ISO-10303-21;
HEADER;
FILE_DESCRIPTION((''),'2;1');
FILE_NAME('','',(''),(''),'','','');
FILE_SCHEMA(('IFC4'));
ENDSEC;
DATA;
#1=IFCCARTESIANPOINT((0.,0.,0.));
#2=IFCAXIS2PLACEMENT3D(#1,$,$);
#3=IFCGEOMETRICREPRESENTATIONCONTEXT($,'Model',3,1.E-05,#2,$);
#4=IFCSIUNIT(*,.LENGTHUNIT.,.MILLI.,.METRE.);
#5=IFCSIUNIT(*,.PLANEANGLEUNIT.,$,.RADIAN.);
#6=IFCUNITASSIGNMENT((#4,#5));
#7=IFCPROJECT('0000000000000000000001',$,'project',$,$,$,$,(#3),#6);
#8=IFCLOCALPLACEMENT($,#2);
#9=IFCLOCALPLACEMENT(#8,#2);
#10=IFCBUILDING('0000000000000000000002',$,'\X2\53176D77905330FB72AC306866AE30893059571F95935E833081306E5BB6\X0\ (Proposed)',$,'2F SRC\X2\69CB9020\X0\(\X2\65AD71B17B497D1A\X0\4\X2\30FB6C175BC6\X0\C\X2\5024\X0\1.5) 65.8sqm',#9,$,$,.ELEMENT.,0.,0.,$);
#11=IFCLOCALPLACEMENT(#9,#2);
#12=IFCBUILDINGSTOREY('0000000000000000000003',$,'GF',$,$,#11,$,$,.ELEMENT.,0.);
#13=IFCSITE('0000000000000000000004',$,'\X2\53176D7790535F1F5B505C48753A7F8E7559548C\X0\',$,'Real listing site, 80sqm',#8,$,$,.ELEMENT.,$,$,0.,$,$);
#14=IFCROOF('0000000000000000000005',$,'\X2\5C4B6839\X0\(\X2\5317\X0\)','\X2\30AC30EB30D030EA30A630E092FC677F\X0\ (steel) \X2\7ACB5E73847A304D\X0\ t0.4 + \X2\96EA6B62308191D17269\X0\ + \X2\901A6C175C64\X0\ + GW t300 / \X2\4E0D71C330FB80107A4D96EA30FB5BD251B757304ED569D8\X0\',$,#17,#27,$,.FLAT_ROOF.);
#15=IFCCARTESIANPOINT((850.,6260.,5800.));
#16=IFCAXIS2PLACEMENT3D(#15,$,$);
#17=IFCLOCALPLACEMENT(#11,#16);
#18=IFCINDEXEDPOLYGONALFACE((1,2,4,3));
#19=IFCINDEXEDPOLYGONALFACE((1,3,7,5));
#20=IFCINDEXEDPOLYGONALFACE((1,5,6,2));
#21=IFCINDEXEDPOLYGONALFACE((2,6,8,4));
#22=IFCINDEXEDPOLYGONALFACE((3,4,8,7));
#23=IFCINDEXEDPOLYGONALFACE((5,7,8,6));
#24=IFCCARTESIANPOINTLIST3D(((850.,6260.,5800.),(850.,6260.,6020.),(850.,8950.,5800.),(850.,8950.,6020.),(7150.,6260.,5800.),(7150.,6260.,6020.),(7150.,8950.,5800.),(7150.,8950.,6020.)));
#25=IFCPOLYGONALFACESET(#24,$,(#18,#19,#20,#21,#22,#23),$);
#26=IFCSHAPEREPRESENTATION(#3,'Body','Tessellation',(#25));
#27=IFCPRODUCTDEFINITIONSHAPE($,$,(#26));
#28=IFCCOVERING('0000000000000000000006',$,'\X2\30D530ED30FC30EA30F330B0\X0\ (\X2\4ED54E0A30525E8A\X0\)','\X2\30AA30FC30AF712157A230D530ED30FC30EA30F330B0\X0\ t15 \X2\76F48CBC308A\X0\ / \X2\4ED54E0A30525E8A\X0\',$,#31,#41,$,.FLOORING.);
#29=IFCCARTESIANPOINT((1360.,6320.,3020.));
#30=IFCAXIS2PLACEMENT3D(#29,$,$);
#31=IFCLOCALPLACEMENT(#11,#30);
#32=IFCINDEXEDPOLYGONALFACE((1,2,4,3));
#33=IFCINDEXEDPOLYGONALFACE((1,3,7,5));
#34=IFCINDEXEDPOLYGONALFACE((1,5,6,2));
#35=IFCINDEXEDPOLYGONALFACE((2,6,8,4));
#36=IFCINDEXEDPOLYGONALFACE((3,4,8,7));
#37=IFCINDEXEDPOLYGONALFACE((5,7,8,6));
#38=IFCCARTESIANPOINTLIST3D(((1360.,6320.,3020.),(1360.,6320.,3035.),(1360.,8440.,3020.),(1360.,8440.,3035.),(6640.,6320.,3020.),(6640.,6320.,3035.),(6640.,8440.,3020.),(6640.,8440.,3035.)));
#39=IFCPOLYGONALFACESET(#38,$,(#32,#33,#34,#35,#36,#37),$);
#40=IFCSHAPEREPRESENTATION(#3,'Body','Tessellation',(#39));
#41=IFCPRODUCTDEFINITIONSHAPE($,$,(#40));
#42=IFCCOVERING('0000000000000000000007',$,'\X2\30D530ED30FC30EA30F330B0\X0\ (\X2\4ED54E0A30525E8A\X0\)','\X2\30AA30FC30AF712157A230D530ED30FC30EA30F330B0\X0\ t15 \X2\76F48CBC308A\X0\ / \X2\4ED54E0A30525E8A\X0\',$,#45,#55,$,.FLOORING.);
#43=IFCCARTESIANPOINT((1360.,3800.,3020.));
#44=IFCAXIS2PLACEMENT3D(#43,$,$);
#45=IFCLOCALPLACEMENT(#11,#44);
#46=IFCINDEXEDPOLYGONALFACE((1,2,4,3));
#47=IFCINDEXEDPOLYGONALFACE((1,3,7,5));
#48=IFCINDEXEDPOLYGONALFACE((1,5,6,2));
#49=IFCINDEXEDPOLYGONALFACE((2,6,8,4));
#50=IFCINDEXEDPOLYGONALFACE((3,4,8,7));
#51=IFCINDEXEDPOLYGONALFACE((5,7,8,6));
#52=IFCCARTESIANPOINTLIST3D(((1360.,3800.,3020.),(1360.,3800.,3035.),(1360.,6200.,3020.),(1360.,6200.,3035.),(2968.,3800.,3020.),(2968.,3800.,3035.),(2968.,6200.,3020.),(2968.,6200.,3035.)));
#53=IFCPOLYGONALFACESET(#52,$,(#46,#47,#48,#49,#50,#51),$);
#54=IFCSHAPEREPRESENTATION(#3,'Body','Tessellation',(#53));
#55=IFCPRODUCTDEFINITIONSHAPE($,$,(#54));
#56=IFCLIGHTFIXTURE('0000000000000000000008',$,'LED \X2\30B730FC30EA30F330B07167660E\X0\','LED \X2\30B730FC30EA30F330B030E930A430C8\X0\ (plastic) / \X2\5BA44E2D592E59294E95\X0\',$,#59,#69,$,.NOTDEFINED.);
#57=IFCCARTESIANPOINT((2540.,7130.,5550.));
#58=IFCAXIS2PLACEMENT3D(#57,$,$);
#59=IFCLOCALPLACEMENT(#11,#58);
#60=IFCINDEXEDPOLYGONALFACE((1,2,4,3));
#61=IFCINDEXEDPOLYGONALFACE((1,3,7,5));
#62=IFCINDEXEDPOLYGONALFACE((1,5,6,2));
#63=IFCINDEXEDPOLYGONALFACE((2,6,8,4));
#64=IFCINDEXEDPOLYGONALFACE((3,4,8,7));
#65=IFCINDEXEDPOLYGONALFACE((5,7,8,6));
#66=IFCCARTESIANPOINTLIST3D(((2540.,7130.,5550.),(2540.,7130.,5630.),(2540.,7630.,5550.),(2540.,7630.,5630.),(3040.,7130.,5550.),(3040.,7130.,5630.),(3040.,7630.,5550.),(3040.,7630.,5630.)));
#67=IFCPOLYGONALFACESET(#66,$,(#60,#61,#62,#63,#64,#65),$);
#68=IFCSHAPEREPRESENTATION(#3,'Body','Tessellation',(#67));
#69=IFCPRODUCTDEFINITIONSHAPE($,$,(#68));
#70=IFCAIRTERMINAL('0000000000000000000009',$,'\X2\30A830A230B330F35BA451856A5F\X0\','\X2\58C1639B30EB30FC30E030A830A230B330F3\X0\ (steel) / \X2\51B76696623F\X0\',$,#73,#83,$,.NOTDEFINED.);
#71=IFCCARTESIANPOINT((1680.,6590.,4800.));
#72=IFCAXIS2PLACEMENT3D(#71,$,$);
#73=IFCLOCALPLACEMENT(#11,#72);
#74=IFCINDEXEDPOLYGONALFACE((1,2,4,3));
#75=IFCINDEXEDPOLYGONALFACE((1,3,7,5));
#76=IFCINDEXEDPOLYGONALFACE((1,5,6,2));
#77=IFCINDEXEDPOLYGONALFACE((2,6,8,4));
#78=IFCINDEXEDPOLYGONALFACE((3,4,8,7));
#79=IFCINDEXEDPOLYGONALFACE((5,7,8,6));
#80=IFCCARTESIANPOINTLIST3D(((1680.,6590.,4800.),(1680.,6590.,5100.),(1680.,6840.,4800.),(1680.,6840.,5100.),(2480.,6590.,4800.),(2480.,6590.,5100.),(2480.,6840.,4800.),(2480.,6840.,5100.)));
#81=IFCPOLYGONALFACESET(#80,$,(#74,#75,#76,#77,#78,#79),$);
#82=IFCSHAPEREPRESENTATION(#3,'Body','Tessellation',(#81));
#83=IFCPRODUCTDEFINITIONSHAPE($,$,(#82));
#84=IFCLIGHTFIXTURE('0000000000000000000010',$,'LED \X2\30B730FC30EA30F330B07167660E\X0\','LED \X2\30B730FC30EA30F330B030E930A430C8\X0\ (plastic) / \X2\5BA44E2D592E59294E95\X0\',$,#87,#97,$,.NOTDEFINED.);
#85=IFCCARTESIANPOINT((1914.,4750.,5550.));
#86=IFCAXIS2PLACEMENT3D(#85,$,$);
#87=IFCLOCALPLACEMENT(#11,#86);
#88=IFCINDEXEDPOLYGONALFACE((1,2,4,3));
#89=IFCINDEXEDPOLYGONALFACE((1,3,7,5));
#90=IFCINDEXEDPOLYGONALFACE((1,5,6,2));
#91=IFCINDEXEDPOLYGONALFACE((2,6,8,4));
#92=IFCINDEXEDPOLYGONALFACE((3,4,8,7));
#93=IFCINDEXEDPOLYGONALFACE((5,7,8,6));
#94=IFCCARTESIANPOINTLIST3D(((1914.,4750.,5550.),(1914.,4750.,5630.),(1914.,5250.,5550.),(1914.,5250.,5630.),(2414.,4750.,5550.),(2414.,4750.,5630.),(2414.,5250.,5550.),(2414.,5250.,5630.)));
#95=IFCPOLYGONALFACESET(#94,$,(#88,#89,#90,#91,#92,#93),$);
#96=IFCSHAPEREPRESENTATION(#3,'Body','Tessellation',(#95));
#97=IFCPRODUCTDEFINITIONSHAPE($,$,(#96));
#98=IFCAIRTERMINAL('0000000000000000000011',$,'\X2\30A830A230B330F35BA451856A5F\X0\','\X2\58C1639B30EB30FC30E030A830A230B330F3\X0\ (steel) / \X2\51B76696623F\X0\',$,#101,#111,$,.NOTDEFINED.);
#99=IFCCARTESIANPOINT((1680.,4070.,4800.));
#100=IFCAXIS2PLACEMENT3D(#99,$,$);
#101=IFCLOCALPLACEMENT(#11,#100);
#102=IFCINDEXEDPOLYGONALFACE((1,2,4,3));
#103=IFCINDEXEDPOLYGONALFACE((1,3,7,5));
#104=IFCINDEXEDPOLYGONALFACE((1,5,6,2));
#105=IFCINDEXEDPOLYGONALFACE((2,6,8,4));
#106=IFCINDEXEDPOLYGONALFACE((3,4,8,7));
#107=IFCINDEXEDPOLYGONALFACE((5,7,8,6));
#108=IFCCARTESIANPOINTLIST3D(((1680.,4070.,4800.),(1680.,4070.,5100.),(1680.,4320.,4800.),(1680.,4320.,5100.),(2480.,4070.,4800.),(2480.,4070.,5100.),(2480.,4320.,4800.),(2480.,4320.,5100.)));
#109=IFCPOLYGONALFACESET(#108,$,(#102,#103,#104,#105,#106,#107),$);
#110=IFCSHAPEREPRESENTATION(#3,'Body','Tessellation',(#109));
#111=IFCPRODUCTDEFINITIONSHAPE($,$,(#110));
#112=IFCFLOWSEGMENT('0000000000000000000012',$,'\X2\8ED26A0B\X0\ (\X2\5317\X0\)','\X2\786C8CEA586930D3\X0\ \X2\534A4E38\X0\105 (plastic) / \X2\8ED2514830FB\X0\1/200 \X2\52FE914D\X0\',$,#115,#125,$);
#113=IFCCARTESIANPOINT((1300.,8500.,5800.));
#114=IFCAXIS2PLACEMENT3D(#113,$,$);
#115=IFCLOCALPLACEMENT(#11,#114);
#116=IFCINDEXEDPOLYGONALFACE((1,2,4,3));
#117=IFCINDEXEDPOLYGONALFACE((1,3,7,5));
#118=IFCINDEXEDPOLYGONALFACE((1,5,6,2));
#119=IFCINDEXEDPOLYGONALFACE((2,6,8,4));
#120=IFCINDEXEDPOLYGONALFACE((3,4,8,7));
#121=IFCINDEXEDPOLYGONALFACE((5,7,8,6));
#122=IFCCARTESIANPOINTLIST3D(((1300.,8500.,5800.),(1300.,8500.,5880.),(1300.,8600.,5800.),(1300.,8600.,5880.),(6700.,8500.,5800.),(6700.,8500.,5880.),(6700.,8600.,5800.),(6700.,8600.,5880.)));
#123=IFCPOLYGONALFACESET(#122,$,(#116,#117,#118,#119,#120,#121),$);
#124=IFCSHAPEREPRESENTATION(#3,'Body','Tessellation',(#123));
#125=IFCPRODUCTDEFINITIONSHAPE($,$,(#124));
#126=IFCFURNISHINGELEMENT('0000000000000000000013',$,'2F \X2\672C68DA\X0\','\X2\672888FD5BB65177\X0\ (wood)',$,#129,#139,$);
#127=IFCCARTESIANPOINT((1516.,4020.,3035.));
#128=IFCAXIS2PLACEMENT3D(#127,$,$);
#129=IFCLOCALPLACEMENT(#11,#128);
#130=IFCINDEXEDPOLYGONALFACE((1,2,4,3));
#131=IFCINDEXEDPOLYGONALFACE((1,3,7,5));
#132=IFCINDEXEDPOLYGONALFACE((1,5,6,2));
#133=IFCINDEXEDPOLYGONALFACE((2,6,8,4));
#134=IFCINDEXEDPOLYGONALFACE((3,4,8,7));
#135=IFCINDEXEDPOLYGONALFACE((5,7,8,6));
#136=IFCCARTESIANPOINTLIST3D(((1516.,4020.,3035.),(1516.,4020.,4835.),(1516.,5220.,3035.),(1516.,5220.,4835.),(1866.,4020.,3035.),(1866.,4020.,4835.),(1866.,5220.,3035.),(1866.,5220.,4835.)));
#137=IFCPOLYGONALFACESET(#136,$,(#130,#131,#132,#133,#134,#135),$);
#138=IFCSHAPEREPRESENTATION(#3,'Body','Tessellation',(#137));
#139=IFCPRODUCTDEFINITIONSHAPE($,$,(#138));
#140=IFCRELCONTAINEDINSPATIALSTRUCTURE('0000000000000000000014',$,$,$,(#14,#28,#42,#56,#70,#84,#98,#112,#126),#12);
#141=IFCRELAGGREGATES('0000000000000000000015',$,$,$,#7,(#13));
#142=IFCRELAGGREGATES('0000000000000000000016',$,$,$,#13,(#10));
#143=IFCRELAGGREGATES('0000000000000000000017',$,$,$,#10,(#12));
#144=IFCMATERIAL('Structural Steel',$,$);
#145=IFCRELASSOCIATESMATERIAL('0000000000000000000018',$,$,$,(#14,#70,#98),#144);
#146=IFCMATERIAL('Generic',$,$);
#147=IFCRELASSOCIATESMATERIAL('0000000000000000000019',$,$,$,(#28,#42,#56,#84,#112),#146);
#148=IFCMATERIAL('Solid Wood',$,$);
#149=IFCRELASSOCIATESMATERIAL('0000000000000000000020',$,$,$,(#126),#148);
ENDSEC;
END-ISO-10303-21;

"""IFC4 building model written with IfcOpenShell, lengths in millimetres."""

from ifc_helpers import new_model, si_unit, frame, frame_2d, origin, place, context, project, spatial, rectangle, extrude, material, element, save


model = new_model("IFC4")

# Units and contexts
model_context = context("Model", 3, precision=1e-05, world=origin())
ifc_project = project(units=[si_unit("LENGTHUNIT", "METRE", prefix="MILLI"), si_unit("PLANEANGLEUNIT", "RADIAN")], contexts=[model_context])

# Site, building, storey
site_placement = place(None, origin())
site = spatial("IfcSite", under=ifc_project, at=site_placement, Name="北海道弟子屈町美留和", ObjectType="Real listing site, 80sqm", CompositionType="ELEMENT", RefElevation=0.0)
building_placement = place(site_placement, origin())
building = spatial("IfcBuilding", under=site, at=building_placement, Name="北海道・犬と暮らす土間広めの家 (Proposed)", ObjectType="2F SRC構造(断熱等級4・気密C値1.5) 65.8sqm", CompositionType="ELEMENT", ElevationOfRefHeight=0.0, ElevationOfTerrain=0.0)
storey_placement = place(building_placement, origin())
storey = spatial("IfcBuildingStorey", under=building, at=storey_placement, Name="GF", CompositionType="ELEMENT", Elevation=0.0)

# Shared definitions
ifc_material_1 = material(Name="Solid Wood")

# Roof
ifc_material_2 = material(Name="Structural Steel")
for number, where, name in (
    (1, (850.0, 6260.0, 5800.0), "屋根(北)"),
):
    element("IfcRoof", number, at=place(storey_placement, frame(where)), inside=storey, material=ifc_material_2, Name=name, Description="ガルバリウム鋼板 (steel) 立平葺き t0.4 + 雪止め金物 + 通気層 + GW t300 / 不燃・耐積雪・寒冷地仕様", PredefinedType="FLAT_ROOF", context=model_context, shape_type="SweptSolid", body=[
        extrude(rectangle(XDim=6300.0, YDim=2690.0, at=frame_2d((3150.0, 1345.0))), frame((850.0, 6260.0, 5800.0)), (0.0, 0.0, 1.0), 220.0),
    ])

# Coverings
ifc_material_3 = material(Name="Generic")
covering_1_placement = place(storey_placement, frame((1360.0, 6320.0, 3020.0)))
element("IfcCovering", 2, at=covering_1_placement, inside=storey, material=ifc_material_3, Name="フローリング (仕上げ床)", Description="オーク無垢フローリング t15 直貼り / 仕上げ床", PredefinedType="FLOORING", context=model_context, shape_type="SweptSolid", body=[
    extrude(rectangle(XDim=5280.0, YDim=2120.0, at=frame_2d((2640.0, 1060.0))), frame((1360.0, 6320.0, 3020.0)), (0.0, 0.0, 1.0), 15.0),
])
covering_2_placement = place(storey_placement, frame((1360.0, 3800.0, 3020.0)))
element("IfcCovering", 3, at=covering_2_placement, inside=storey, material=ifc_material_3, Name="フローリング (仕上げ床)", Description="オーク無垢フローリング t15 直貼り / 仕上げ床", PredefinedType="FLOORING", context=model_context, shape_type="SweptSolid", body=[
    extrude(rectangle(XDim=1608.0, YDim=2400.0, at=frame_2d((804.0, 1200.0))), frame((1360.0, 3800.0, 3020.0)), (0.0, 0.0, 1.0), 15.0),
])

# Light fixture
light_fixture_1_placement = place(storey_placement, frame((2540.0, 7130.0, 5550.0)))
element("IfcLightFixture", 4, at=light_fixture_1_placement, inside=storey, material=ifc_material_3, Name="LED シーリング照明", Description="LED シーリングライト (plastic) / 室中央天井", PredefinedType="NOTDEFINED", context=model_context, shape_type="SweptSolid", body=[
    extrude(rectangle(XDim=500.0, YDim=500.0, at=frame_2d((250.0, 250.0))), frame((2540.0, 7130.0, 5550.0)), (0.0, 0.0, 1.0), 80.0),
])

# Air terminal
air_terminal_1_placement = place(storey_placement, frame((1680.0, 6590.0, 4800.0)))
element("IfcAirTerminal", 5, at=air_terminal_1_placement, inside=storey, material=ifc_material_2, Name="エアコン室内機", Description="壁掛ルームエアコン (steel) / 冷暖房", PredefinedType="NOTDEFINED", context=model_context, shape_type="SweptSolid", body=[
    extrude(rectangle(XDim=800.0, YDim=250.0, at=frame_2d((400.0, 125.0))), frame((1680.0, 6590.0, 4800.0)), (0.0, 0.0, 1.0), 300.0),
])

# Light fixture
light_fixture_2_placement = place(storey_placement, frame((1914.0, 4750.0, 5550.0)))
element("IfcLightFixture", 6, at=light_fixture_2_placement, inside=storey, material=ifc_material_3, Name="LED シーリング照明", Description="LED シーリングライト (plastic) / 室中央天井", PredefinedType="NOTDEFINED", context=model_context, shape_type="SweptSolid", body=[
    extrude(rectangle(XDim=500.0, YDim=500.0, at=frame_2d((250.0, 250.0))), frame((1914.0, 4750.0, 5550.0)), (0.0, 0.0, 1.0), 80.0),
])

# Air terminal
air_terminal_2_placement = place(storey_placement, frame((1680.0, 4070.0, 4800.0)))
element("IfcAirTerminal", 7, at=air_terminal_2_placement, inside=storey, material=ifc_material_2, Name="エアコン室内機", Description="壁掛ルームエアコン (steel) / 冷暖房", PredefinedType="NOTDEFINED", context=model_context, shape_type="SweptSolid", body=[
    extrude(rectangle(XDim=800.0, YDim=250.0, at=frame_2d((400.0, 125.0))), frame((1680.0, 4070.0, 4800.0)), (0.0, 0.0, 1.0), 300.0),
])

# Flow segment
flow_segment_placement = place(storey_placement, frame((1300.0, 8500.0, 5800.0)))
element("IfcFlowSegment", 8, at=flow_segment_placement, inside=storey, material=ifc_material_3, Name="軒樋 (北)", Description="硬質塩ビ 半丸105 (plastic) / 軒先・1/200 勾配", context=model_context, shape_type="SweptSolid", body=[
    extrude(rectangle(XDim=5400.0, YDim=100.0, at=frame_2d((2700.0, 50.0))), frame((1300.0, 8500.0, 5800.0)), (0.0, 0.0, 1.0), 80.0),
])

# Furnishing element
furnishing_placement = place(storey_placement, frame((1516.0, 4020.0, 3035.0)))
element("IfcFurnishingElement", 9, at=furnishing_placement, inside=storey, material=ifc_material_1, Name="2F 本棚", Description="木製家具 (wood)", context=model_context, shape_type="SweptSolid", body=[
    extrude(rectangle(XDim=350.0, YDim=1200.0, at=frame_2d((175.0, 600.0))), frame((1516.0, 4020.0, 3035.0)), (0.0, 0.0, 1.0), 1800.0),
])

save(model, "model.ifc")
